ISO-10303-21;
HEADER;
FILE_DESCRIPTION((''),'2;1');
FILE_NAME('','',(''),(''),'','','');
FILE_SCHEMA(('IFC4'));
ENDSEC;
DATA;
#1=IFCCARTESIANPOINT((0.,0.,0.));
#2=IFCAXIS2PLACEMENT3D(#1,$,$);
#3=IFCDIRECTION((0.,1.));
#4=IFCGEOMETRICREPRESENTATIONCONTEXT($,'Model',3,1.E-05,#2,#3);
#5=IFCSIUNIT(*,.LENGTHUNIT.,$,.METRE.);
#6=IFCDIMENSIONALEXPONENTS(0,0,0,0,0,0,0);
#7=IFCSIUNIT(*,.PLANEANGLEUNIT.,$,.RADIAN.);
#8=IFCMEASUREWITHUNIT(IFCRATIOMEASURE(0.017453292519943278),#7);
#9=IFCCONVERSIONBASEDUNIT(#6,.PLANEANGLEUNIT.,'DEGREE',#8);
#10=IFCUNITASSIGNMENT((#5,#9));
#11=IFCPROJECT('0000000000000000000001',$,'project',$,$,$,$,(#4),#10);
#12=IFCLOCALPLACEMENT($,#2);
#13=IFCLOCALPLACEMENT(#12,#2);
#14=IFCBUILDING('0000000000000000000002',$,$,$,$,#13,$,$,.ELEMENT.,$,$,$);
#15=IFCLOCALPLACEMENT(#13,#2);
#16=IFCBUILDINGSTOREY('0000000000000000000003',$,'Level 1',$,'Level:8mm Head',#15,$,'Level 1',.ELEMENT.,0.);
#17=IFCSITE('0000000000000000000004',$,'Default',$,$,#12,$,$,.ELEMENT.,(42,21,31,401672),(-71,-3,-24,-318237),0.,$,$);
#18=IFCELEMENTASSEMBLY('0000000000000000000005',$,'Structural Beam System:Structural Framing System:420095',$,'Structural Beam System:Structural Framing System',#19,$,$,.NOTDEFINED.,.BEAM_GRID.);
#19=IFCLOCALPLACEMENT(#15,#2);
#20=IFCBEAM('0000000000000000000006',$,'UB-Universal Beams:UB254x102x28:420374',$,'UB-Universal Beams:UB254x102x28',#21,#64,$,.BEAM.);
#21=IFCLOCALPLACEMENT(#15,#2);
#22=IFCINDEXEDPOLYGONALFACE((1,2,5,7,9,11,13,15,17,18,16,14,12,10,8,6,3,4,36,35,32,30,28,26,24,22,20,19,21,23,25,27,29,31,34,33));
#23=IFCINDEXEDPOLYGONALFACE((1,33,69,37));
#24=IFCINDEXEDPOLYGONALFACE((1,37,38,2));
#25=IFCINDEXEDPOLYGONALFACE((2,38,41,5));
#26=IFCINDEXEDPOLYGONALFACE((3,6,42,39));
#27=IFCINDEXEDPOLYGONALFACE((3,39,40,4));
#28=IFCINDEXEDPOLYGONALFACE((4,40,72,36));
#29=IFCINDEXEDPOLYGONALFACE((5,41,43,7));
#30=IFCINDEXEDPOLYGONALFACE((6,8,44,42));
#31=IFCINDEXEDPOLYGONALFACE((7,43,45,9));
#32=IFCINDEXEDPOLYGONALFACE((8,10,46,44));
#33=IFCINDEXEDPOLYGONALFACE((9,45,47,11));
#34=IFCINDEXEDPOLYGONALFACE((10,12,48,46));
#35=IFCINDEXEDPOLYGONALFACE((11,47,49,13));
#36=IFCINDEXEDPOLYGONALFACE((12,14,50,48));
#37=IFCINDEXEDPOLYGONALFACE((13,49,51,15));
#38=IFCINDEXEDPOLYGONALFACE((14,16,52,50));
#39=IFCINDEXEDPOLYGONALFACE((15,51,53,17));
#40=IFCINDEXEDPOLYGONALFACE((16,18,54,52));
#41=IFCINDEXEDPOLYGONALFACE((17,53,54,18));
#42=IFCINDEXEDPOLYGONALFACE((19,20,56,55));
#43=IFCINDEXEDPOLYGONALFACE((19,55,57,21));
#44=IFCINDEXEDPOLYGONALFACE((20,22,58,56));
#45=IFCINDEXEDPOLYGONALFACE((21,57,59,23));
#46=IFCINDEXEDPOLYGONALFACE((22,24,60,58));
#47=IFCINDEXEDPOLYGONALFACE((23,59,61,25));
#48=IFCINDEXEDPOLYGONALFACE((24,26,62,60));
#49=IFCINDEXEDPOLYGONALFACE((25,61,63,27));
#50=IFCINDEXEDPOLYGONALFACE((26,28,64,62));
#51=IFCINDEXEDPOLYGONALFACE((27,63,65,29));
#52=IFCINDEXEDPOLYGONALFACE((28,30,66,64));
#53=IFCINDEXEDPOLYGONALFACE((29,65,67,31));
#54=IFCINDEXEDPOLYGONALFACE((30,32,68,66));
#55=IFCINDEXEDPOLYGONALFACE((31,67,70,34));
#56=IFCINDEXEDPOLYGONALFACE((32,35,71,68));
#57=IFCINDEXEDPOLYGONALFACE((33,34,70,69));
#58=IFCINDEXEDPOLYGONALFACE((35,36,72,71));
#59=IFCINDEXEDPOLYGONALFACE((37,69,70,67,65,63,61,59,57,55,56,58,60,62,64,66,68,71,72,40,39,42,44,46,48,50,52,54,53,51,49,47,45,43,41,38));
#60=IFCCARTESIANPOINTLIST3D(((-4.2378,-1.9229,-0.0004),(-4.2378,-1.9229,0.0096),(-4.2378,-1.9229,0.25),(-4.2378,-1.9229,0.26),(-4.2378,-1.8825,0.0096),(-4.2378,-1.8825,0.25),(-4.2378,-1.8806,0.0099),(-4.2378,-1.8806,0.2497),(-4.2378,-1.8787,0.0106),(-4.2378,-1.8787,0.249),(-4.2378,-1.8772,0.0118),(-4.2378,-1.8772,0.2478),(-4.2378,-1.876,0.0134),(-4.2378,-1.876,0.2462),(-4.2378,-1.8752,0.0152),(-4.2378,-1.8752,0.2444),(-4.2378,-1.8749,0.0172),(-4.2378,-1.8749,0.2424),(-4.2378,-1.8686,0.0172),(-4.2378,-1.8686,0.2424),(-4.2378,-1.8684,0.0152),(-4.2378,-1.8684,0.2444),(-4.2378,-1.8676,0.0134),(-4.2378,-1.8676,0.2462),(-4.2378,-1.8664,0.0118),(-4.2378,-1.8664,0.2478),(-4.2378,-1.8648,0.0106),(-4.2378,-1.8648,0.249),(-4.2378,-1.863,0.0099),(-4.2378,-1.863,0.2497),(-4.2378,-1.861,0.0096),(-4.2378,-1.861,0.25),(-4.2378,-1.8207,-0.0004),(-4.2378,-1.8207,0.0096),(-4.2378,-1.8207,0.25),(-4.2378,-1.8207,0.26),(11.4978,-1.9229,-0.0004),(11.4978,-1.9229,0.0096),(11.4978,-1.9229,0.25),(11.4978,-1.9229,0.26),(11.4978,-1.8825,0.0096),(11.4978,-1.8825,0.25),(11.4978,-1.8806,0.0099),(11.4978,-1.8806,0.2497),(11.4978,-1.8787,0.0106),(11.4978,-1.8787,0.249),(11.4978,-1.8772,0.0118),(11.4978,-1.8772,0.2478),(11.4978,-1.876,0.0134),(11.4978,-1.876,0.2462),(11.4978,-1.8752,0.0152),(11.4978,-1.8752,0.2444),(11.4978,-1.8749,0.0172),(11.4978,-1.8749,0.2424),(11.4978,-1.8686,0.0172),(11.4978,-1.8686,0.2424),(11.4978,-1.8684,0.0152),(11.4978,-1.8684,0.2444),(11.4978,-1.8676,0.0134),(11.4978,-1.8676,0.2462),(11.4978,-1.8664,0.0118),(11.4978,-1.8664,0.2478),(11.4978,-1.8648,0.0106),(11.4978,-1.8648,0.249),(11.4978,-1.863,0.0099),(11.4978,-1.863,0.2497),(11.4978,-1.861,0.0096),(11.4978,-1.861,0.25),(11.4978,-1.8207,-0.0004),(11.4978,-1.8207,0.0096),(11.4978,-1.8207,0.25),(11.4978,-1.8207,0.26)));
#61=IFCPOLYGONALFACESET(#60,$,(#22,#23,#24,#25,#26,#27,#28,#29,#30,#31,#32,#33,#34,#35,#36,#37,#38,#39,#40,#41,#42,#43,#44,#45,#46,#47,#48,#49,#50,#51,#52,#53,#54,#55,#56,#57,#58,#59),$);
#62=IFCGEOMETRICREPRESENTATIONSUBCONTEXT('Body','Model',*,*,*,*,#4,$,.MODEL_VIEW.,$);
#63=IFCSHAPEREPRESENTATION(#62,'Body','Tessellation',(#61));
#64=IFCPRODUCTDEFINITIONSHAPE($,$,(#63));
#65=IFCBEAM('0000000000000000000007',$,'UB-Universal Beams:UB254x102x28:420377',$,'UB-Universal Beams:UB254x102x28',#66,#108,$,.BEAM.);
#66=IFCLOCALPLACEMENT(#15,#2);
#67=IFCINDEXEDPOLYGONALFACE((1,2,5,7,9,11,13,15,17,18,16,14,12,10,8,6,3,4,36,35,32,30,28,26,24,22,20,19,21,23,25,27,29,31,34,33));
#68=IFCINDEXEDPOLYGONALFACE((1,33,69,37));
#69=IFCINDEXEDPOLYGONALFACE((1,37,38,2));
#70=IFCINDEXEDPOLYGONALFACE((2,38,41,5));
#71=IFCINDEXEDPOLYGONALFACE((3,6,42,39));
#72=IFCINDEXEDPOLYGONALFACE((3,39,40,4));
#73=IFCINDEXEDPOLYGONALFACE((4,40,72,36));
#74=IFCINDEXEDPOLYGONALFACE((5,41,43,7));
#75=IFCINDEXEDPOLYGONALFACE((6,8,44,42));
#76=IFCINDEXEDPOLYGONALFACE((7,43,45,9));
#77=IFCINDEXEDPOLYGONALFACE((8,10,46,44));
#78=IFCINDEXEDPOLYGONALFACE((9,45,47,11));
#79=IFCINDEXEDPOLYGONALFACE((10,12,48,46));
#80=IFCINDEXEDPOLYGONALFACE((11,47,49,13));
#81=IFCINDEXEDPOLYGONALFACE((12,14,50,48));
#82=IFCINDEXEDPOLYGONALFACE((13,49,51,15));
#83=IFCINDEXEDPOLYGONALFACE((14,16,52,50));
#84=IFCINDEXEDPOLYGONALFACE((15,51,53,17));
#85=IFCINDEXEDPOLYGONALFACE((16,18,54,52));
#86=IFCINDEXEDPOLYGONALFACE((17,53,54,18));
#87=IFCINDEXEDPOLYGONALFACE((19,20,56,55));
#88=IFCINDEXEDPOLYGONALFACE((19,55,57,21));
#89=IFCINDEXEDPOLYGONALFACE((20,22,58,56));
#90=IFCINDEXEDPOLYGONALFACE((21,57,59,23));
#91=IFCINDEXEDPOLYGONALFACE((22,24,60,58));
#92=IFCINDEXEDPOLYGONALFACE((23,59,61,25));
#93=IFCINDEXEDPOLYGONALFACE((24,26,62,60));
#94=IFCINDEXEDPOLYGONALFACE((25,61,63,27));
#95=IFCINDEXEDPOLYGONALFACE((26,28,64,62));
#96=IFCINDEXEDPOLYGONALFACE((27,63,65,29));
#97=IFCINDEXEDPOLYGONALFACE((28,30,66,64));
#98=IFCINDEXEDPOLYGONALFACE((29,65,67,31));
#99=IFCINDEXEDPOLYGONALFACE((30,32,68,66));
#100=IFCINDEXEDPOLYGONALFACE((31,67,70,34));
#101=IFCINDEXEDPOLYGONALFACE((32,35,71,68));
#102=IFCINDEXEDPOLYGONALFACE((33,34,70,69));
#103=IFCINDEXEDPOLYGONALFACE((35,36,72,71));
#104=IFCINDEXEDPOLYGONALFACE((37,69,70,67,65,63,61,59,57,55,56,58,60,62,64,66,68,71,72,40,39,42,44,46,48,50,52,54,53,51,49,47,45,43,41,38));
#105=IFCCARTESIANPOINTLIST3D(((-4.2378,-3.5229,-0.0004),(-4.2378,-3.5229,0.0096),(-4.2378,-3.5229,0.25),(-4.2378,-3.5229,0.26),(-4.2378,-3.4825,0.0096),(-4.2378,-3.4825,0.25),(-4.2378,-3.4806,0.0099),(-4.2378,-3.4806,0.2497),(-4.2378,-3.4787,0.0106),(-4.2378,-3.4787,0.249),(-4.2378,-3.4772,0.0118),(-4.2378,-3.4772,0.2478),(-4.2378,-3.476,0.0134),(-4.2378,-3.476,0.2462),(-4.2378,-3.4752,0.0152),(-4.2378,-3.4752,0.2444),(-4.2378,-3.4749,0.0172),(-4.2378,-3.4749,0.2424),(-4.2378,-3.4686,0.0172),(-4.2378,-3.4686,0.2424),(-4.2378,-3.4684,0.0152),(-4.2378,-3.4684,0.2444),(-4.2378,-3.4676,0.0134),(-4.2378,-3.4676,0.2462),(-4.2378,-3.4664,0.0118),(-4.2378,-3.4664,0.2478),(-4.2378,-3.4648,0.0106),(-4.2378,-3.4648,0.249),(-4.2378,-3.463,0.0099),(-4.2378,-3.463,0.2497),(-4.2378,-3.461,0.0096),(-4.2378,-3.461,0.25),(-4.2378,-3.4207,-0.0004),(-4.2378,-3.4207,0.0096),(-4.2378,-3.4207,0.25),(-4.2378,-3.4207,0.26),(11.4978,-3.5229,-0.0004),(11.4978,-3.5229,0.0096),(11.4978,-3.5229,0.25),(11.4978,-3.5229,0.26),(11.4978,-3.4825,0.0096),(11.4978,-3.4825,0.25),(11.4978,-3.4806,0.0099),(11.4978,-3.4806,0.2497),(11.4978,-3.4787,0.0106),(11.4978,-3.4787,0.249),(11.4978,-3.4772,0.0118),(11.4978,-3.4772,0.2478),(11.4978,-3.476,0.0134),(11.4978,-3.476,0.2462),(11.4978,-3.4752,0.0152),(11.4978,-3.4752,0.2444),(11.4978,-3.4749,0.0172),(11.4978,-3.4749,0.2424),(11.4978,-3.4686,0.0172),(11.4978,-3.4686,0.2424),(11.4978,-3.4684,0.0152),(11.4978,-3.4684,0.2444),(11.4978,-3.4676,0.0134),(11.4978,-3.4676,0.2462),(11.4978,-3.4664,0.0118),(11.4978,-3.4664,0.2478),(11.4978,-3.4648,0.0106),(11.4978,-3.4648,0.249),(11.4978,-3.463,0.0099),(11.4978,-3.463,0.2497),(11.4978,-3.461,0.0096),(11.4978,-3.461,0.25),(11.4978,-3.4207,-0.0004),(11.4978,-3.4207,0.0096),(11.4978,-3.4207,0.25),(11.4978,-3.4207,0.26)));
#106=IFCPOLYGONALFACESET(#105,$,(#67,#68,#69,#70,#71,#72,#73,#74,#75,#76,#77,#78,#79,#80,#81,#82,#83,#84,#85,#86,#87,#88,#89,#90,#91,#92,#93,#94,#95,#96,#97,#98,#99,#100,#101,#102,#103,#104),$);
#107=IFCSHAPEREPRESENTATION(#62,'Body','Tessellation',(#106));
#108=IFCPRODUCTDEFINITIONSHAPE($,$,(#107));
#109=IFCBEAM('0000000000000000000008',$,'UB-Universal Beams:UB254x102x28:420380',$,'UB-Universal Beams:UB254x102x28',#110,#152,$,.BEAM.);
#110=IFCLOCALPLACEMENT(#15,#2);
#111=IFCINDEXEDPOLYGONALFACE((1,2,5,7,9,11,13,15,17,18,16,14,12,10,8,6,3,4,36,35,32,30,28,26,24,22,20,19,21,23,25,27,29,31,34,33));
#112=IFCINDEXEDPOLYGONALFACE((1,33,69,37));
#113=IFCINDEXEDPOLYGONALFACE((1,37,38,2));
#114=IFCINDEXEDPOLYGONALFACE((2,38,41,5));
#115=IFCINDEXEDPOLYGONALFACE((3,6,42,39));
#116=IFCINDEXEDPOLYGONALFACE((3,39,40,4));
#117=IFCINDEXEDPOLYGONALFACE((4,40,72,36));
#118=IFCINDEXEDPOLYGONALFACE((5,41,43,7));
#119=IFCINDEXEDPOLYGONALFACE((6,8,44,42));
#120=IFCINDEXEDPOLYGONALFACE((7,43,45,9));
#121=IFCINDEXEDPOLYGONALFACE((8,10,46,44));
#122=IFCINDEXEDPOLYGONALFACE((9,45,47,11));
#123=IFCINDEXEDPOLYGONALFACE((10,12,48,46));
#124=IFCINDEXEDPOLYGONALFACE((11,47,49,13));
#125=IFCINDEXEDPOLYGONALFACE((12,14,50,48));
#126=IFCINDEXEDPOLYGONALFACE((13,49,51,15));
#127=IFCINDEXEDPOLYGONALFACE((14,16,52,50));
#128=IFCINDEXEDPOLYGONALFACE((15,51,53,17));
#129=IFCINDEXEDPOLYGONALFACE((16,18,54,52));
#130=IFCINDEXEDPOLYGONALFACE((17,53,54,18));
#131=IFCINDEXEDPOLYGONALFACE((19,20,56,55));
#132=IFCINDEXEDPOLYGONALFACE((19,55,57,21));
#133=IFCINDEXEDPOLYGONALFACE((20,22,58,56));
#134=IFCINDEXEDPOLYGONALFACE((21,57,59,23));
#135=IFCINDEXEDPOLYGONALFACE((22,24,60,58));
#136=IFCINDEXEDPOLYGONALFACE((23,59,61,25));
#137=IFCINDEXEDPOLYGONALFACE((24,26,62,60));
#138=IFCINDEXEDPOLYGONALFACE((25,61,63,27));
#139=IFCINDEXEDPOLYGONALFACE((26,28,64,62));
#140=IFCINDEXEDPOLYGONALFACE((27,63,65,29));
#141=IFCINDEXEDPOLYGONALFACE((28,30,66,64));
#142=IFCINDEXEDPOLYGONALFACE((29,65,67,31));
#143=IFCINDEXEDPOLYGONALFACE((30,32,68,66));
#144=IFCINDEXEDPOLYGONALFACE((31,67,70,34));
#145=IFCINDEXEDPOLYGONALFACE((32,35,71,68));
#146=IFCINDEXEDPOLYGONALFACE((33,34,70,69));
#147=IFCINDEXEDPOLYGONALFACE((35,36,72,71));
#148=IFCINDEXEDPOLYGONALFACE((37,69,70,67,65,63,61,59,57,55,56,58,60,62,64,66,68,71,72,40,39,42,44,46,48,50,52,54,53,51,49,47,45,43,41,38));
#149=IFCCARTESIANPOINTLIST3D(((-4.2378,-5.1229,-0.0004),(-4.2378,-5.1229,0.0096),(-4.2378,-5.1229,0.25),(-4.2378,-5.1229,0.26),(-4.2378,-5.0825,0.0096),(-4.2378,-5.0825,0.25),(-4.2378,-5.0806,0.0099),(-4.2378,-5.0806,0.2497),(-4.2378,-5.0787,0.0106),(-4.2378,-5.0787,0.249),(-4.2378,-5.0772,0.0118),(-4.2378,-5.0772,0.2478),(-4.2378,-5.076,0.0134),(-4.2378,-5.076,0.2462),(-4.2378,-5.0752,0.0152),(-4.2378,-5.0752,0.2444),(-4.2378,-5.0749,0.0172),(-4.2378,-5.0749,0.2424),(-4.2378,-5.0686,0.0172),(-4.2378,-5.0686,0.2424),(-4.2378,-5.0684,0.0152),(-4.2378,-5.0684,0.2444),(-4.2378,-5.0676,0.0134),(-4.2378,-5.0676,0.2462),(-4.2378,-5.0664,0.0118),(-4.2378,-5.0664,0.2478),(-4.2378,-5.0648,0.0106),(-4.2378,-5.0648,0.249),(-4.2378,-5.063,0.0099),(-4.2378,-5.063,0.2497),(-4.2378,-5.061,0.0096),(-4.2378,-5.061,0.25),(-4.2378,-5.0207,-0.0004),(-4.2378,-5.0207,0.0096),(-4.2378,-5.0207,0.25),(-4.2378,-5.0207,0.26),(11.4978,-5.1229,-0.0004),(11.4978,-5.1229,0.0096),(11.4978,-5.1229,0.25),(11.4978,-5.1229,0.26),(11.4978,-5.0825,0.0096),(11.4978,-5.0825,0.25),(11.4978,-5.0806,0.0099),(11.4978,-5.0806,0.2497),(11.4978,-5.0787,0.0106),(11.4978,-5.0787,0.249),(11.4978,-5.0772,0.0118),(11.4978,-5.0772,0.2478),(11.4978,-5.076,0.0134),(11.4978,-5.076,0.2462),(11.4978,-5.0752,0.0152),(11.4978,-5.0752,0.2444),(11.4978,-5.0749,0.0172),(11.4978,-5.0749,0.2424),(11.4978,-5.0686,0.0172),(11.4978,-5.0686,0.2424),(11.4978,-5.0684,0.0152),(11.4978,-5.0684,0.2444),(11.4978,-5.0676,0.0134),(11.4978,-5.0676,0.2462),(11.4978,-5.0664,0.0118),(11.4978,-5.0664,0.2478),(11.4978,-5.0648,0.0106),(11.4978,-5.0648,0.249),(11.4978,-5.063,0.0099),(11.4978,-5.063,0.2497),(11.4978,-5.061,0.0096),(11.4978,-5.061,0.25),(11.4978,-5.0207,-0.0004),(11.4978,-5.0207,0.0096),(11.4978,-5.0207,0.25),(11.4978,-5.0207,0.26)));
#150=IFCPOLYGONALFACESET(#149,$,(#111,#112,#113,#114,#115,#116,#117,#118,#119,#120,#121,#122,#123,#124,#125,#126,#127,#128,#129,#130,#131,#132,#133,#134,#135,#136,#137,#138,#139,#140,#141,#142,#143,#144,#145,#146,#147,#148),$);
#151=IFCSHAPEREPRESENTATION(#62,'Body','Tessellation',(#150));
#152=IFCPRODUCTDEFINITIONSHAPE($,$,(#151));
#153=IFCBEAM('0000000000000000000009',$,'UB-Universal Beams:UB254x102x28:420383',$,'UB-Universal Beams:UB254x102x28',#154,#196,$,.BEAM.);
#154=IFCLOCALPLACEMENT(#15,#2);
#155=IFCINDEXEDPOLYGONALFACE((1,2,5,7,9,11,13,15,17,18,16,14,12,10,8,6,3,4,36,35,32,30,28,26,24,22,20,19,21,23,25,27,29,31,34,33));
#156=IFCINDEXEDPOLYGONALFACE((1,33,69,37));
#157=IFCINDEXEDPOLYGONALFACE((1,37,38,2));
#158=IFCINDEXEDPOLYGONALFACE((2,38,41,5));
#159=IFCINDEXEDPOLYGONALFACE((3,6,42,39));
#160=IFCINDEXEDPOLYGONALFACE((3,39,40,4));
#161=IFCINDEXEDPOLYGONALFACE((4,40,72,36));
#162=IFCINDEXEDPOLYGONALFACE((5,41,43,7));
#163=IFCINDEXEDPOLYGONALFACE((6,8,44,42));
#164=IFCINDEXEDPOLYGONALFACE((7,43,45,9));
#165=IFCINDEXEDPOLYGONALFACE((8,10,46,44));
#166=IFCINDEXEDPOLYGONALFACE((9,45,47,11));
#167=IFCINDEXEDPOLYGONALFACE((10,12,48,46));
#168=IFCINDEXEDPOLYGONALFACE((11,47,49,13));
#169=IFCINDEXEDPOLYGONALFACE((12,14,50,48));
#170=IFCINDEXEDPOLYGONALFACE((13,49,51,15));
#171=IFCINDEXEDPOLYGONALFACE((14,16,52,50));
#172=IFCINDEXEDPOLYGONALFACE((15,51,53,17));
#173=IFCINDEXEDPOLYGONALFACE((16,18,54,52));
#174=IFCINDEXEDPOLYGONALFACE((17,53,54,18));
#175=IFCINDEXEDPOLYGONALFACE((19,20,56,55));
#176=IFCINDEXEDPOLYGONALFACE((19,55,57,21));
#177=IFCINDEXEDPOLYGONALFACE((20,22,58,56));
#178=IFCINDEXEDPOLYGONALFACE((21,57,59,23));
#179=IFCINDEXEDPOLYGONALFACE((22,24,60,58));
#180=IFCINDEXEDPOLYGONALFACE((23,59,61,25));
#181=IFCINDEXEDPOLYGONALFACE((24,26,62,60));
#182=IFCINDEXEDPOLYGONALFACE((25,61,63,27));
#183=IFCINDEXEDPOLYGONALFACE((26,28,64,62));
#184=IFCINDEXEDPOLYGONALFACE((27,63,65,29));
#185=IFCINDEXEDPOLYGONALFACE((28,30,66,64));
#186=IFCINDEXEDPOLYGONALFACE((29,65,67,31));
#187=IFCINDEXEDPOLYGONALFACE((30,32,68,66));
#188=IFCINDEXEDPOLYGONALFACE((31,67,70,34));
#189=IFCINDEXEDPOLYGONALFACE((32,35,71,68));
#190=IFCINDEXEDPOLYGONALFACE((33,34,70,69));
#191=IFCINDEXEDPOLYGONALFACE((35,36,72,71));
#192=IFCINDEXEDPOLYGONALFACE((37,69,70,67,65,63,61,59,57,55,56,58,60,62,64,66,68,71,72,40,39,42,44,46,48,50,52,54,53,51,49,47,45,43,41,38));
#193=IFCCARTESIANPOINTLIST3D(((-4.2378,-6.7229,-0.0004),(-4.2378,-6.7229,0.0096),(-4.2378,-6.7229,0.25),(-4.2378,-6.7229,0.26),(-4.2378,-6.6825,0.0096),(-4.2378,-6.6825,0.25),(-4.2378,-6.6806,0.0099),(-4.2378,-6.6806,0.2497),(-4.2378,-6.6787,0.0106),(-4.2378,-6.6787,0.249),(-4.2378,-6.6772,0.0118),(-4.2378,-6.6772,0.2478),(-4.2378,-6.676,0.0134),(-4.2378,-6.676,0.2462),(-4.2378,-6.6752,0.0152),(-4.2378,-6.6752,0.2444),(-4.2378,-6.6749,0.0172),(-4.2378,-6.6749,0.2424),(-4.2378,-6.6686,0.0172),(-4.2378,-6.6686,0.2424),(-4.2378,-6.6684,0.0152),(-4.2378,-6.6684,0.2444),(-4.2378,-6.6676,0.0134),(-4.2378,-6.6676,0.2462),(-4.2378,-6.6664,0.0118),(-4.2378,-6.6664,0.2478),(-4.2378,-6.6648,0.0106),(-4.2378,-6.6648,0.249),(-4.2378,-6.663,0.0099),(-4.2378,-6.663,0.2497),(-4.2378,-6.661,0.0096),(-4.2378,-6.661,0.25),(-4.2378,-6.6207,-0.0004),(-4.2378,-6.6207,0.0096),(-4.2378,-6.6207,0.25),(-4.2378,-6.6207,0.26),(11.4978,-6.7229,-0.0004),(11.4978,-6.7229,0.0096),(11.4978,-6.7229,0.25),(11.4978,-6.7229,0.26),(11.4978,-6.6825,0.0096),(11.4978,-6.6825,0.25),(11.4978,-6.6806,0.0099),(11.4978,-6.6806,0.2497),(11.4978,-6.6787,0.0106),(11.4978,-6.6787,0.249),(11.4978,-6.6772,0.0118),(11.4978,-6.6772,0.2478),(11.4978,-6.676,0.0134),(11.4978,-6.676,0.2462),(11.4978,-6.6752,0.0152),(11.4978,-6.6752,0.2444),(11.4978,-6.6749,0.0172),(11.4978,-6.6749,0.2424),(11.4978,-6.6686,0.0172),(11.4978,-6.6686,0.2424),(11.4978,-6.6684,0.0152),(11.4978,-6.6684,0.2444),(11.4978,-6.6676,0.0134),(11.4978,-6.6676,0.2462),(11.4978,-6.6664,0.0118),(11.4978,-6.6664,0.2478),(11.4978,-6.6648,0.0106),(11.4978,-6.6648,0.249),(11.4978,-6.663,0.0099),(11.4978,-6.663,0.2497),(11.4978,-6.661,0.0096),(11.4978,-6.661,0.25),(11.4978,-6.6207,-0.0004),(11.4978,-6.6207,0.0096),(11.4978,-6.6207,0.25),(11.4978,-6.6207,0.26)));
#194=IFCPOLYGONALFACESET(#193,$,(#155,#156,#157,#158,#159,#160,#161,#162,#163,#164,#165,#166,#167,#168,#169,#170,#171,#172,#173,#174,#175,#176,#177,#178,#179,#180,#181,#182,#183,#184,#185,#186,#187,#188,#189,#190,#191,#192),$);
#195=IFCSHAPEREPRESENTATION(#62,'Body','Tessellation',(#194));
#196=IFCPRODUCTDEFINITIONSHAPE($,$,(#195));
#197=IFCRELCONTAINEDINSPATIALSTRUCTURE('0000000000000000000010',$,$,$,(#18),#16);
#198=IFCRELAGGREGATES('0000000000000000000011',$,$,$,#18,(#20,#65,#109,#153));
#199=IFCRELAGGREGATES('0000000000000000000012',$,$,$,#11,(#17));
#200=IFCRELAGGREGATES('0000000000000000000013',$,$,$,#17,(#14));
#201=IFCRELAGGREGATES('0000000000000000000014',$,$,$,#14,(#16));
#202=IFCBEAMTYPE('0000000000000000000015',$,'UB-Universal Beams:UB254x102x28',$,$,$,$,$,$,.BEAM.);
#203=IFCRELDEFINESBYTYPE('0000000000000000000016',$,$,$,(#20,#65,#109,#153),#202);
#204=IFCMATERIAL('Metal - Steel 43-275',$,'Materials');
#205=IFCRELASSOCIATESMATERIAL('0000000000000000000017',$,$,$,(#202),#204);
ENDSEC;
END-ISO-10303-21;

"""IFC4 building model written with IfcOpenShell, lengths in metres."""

from ifc_helpers import new_model, entity, si_unit, converted_unit, direction, frame, frame_2d, origin, place, context, subcontext, project, spatial, i_section, extrude, source, transform, mapped, material, material_profile, profile_set, type_object, type_shapes, element, aggregate, save


model = new_model("IFC4")

# Units and contexts
model_context = context("Model", 3, precision=1e-05, world=origin(), true_north=direction((0.0, 1.0)))
body_context = subcontext(model_context, "Body", "Model", "MODEL_VIEW")
ifc_project = project(units=[si_unit("LENGTHUNIT", "METRE"), converted_unit("PLANEANGLEUNIT", "DEGREE", entity("IfcRatioMeasure", 0.017453292519943278), si_unit("PLANEANGLEUNIT", "RADIAN"), dimensions=[0, 0, 0, 0, 0, 0, 0])], contexts=[model_context])

# Site, building, storey
site_placement = place(None, origin())
site = spatial("IfcSite", under=ifc_project, at=site_placement, Name="Default", CompositionType="ELEMENT", RefLatitude=(42, 21, 31, 401672), RefLongitude=(-71, -3, -24, -318237), RefElevation=0.0)
building_placement = place(site_placement, origin())
building = spatial("IfcBuilding", under=site, at=building_placement, CompositionType="ELEMENT")
storey_placement = place(building_placement, origin())
storey = spatial("IfcBuildingStorey", under=building, at=storey_placement, Name="Level 1", ObjectType="Level:8mm Head", LongName="Level 1", CompositionType="ELEMENT", Elevation=0.0)

# Shared definitions
ifc_material_1 = material(Name="Metal - Steel 43-275", Category="Materials")

# Element assembly, beams
assembly_placement = place(storey_placement, origin())
assembly = element("IfcElementAssembly", 1, at=assembly_placement, inside=storey, Name="Structural Beam System:Structural Framing System:420095", ObjectType="Structural Beam System:Structural Framing System", AssemblyPlace="NOTDEFINED", PredefinedType="BEAM_GRID")
ifc_material_profile_1 = material_profile(ifc_material_1, i_section(OverallWidth=0.1022, OverallDepth=0.2604, WebThickness=0.0063, FlangeThickness=0.01, FilletRadius=0.0076, at=frame_2d((0.0, 0.0), x_axis=(0.0, 1.0))), Name="UB254x102x28")
ifc_profile_set_1 = profile_set([ifc_material_profile_1], Name="UB254x102x28")
beam_type_1 = type_object("IfcBeamType", Name="UB-Universal Beams:UB254x102x28", PredefinedType="BEAM", material=ifc_profile_set_1)
shared_shape_1 = source(origin(), body_context, "Body", "SweptSolid", [
    extrude(i_section(OverallWidth=0.1022, OverallDepth=0.2604, WebThickness=0.0063, FlangeThickness=0.01, FilletRadius=0.0076, at=frame_2d((0.0, 0.0), x_axis=(0.0, 1.0))), frame((-7.8373, 0.0, 0.0), z_axis=(1.0, 0.0, 0.0), x_axis=(0.0, 0.0, -1.0)), (0.0, 0.0, 1.0), 15.7356),
])
type_shapes(beam_type_1, [shared_shape_1])
beam_1_placement = place(assembly_placement, frame((3.5995, -1.8718, 0.1298)))
beam_1 = element("IfcBeam", 2, at=beam_1_placement, type_object=beam_type_1, Name="UB-Universal Beams:UB254x102x28:420374", ObjectType="UB-Universal Beams:UB254x102x28", PredefinedType="BEAM", context=body_context, shape_type="MappedRepresentation", body=[
    mapped(shared_shape_1, transform((0.0, 0.0, 0.0), scale=1.0)),
])
beam_2_placement = place(assembly_placement, frame((3.5995, -3.4718, 0.1298)))
beam_2 = element("IfcBeam", 3, at=beam_2_placement, type_object=beam_type_1, Name="UB-Universal Beams:UB254x102x28:420377", ObjectType="UB-Universal Beams:UB254x102x28", PredefinedType="BEAM", context=body_context, shape_type="MappedRepresentation", body=[
    mapped(shared_shape_1, transform((0.0, 0.0, 0.0), scale=1.0)),
])
beam_3_placement = place(assembly_placement, frame((3.5995, -5.0718, 0.1298)))
beam_3 = element("IfcBeam", 4, at=beam_3_placement, type_object=beam_type_1, Name="UB-Universal Beams:UB254x102x28:420380", ObjectType="UB-Universal Beams:UB254x102x28", PredefinedType="BEAM", context=body_context, shape_type="MappedRepresentation", body=[
    mapped(shared_shape_1, transform((0.0, 0.0, 0.0), scale=1.0)),
])
beam_4_placement = place(assembly_placement, frame((3.5995, -6.6718, 0.1298)))
beam_4 = element("IfcBeam", 5, at=beam_4_placement, type_object=beam_type_1, Name="UB-Universal Beams:UB254x102x28:420383", ObjectType="UB-Universal Beams:UB254x102x28", PredefinedType="BEAM", context=body_context, shape_type="MappedRepresentation", body=[
    mapped(shared_shape_1, transform((0.0, 0.0, 0.0), scale=1.0)),
])
aggregate(assembly, [beam_1, beam_2, beam_3, beam_4])

save(model, "model.ifc")
